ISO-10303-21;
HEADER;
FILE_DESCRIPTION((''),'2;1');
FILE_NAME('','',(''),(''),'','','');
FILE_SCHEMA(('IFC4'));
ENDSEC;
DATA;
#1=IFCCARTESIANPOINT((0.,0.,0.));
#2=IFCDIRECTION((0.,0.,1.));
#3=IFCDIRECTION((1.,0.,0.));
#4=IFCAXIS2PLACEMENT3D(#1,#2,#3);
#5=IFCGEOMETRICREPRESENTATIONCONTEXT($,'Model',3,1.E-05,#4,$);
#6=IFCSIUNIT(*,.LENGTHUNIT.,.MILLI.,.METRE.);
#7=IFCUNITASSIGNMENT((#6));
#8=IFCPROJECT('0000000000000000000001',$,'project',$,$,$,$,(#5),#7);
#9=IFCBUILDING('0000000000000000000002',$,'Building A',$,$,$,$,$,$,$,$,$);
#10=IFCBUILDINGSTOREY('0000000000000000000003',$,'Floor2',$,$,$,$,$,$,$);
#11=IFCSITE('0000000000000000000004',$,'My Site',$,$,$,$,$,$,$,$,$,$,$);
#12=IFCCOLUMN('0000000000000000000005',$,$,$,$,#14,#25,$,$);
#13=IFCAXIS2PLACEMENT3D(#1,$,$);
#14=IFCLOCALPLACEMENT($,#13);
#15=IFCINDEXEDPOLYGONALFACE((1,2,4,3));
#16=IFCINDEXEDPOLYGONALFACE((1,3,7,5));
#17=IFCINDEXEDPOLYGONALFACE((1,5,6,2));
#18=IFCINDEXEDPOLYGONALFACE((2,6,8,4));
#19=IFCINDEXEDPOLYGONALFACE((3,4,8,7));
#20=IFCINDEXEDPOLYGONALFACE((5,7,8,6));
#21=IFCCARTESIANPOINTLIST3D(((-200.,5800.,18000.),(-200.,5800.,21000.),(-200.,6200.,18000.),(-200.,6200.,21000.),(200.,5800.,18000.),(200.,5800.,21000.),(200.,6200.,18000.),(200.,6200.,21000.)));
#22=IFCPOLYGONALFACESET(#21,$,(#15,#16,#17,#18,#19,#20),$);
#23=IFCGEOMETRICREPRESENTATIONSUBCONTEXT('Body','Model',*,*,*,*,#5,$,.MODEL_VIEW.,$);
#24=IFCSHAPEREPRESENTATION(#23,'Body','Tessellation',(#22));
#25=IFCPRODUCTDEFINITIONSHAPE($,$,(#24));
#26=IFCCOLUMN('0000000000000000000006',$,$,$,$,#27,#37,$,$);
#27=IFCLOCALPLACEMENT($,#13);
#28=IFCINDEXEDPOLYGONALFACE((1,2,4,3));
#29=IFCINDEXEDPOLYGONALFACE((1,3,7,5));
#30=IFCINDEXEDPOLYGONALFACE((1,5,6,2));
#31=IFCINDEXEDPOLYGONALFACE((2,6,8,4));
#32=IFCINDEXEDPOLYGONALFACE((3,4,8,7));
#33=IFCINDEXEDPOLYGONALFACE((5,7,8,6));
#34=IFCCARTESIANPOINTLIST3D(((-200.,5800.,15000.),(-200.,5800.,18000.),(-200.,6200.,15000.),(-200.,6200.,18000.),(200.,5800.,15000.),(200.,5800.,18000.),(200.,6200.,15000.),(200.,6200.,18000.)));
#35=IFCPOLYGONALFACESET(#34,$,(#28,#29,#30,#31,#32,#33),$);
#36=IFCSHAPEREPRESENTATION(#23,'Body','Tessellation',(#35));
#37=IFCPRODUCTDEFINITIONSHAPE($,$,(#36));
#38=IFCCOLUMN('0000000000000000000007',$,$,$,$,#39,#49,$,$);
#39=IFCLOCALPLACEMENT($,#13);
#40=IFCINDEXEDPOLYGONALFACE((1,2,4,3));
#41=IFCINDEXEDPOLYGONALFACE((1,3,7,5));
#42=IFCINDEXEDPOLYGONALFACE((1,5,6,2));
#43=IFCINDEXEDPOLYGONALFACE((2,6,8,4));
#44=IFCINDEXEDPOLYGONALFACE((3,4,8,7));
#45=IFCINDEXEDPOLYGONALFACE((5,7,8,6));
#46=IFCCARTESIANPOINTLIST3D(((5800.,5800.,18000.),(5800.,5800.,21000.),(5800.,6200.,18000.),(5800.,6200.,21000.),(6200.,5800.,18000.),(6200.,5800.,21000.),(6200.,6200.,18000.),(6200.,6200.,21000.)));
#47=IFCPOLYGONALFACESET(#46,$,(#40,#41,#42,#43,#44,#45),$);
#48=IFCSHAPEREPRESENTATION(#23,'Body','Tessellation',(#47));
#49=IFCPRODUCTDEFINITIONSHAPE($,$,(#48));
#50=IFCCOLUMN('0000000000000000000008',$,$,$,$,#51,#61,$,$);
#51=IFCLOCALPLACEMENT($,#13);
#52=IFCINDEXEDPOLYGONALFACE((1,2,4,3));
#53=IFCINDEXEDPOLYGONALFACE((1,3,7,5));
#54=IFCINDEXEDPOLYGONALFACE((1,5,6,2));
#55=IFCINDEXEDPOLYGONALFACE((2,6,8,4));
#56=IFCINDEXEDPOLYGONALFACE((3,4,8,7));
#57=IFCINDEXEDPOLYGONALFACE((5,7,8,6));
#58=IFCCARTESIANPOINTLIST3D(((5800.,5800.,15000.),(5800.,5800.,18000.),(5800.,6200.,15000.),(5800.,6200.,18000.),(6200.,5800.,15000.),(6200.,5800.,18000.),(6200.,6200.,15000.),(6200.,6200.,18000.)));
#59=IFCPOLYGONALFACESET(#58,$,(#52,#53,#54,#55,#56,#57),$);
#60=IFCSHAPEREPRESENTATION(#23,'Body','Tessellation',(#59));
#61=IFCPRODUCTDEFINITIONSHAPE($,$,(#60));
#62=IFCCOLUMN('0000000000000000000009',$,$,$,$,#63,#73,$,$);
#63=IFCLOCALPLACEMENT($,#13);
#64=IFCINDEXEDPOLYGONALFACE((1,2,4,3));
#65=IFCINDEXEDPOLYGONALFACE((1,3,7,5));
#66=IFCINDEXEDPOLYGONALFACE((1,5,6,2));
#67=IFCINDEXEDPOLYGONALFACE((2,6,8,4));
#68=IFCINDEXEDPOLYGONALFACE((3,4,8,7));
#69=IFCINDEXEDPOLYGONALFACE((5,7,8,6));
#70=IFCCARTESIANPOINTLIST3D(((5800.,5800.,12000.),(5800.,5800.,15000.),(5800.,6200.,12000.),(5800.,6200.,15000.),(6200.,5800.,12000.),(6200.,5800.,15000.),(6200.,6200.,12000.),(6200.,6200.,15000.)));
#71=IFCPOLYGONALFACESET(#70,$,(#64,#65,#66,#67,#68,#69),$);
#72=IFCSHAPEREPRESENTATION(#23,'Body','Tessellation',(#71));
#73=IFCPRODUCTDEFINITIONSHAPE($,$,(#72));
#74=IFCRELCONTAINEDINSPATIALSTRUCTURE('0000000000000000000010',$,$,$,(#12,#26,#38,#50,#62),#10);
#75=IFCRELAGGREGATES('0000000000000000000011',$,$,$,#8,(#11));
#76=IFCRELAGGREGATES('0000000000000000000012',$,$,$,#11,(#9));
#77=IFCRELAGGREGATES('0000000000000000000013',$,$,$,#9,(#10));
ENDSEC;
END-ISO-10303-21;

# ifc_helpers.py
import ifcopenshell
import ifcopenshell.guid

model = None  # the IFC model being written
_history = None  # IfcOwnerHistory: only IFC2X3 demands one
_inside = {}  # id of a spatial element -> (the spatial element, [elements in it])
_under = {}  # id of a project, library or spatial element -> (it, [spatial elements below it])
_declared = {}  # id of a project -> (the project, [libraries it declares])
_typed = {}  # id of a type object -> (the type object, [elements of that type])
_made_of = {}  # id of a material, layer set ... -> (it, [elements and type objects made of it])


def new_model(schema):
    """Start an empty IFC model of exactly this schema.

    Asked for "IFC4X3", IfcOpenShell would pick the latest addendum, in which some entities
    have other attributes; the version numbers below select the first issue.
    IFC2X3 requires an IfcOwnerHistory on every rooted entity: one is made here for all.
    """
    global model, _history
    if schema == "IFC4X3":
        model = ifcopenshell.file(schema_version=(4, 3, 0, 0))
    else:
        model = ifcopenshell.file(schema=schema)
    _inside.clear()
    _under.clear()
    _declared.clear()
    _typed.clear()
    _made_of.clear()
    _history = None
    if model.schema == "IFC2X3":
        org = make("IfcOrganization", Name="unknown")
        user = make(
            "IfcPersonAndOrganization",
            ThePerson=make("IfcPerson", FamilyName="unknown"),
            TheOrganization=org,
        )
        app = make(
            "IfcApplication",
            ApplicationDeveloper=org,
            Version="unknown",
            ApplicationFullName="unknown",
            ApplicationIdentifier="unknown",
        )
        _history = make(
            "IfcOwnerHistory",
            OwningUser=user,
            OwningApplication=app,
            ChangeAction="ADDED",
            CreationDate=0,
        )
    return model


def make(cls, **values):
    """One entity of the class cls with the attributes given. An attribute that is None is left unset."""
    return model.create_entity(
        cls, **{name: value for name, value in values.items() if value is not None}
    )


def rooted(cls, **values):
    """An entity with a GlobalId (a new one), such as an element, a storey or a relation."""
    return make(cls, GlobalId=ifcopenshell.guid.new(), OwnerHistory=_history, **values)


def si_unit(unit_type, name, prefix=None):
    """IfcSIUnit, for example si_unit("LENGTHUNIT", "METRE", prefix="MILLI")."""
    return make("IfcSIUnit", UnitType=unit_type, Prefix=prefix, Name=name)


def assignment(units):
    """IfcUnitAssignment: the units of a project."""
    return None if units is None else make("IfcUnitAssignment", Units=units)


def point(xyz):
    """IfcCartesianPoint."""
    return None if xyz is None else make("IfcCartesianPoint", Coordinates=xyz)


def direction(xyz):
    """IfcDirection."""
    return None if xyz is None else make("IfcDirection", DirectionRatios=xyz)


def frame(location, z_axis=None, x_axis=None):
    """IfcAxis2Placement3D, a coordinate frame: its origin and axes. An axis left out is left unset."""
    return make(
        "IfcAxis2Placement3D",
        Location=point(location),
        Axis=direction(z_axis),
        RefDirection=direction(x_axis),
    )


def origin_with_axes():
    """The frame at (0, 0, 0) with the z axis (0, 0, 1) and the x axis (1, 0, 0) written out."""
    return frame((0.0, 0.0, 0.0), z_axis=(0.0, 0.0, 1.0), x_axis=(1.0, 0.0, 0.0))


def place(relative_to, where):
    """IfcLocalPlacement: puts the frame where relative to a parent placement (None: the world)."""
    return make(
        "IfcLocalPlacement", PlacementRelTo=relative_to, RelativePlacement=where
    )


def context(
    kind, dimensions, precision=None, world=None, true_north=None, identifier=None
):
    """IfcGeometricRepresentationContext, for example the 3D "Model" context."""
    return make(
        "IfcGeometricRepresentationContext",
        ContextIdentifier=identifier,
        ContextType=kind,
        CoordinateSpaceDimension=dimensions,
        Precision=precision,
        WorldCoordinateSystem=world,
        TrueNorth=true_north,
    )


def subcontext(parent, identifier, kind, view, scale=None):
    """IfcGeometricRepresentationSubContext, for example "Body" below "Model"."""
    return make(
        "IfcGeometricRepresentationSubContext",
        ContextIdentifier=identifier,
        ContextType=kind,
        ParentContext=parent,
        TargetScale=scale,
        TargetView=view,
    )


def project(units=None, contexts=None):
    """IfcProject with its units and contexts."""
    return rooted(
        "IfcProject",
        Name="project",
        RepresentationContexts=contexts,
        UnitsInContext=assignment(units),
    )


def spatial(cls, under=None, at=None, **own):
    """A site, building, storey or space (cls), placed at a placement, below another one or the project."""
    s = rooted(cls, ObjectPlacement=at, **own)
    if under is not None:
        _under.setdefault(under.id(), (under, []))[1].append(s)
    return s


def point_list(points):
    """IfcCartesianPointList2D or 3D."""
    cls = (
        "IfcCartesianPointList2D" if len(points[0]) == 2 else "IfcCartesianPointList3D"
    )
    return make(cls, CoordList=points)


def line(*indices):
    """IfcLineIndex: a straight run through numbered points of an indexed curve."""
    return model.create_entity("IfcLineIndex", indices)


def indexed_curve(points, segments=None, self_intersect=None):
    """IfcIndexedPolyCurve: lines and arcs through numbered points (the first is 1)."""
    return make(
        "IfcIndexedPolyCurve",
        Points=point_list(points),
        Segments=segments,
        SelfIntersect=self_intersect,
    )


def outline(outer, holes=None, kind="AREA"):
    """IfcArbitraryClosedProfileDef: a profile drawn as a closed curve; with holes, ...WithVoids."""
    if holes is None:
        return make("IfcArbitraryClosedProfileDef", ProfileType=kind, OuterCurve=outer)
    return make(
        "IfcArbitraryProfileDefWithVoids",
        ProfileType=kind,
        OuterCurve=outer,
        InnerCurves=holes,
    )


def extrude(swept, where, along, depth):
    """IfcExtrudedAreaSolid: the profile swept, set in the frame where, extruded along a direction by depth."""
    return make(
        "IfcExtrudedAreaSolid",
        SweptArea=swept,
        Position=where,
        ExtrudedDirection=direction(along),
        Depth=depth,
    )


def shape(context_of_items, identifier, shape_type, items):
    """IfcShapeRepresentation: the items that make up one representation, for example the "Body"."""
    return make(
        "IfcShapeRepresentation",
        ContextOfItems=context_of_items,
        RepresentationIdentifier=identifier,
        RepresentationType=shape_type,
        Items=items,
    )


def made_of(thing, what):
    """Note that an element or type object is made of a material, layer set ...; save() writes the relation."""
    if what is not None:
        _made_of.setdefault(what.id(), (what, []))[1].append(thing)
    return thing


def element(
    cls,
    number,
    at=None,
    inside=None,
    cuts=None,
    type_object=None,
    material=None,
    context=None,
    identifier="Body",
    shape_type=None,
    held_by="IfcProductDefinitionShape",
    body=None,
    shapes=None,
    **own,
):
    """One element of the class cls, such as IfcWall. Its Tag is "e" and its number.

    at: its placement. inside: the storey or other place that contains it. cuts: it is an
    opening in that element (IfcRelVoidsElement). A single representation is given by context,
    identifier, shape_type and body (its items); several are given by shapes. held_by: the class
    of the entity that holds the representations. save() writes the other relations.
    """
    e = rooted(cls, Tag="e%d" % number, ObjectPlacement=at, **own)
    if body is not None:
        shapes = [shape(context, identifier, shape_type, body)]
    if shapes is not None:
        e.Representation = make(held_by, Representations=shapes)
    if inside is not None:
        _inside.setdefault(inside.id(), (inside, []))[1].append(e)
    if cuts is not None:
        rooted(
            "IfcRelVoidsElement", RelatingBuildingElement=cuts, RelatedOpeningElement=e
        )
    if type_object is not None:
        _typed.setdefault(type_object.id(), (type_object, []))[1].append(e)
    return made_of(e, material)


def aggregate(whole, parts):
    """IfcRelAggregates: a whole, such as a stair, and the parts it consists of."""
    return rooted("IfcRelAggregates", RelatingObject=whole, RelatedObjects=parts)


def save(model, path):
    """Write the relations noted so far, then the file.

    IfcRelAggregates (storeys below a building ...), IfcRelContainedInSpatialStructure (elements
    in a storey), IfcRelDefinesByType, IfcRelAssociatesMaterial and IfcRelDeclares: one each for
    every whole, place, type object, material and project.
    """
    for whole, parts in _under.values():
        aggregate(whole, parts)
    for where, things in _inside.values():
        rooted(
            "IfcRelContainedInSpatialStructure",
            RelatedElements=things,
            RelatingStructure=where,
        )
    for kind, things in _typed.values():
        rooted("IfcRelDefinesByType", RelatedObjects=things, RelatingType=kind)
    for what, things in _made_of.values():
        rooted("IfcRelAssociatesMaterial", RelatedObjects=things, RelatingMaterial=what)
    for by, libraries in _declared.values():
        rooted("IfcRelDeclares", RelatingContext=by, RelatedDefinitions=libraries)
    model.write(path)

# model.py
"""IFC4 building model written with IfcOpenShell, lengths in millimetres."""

from ifc_helpers import new_model, si_unit, frame, origin_with_axes, place, context, subcontext, project, spatial, line, indexed_curve, outline, extrude, element, save


model = new_model("IFC4")

# Units and contexts
model_context = context("Model", 3, precision=1e-05, world=origin_with_axes())
body_context = subcontext(model_context, "Body", "Model", "MODEL_VIEW")
ifc_project = project(units=[si_unit("LENGTHUNIT", "METRE", prefix="MILLI")], contexts=[model_context])

# Site, building, storey
site = spatial("IfcSite", under=ifc_project, Name="My Site")
building = spatial("IfcBuilding", under=site, Name="Building A")
storey = spatial("IfcBuildingStorey", under=building, Name="Floor2")

# Columns
for number, where, z_axis, x_axis in (
    (1, (0.0, 6000.0, 18000.0), (0.0, 0.0, 1.0), (1.0, 0.0, 0.0)),
    (2, (0.0, 6000.0, 15000.0), (0.0, 0.0, 1.0), (1.0, 0.0, 0.0)),
    (3, (6000.0, 6000.0, 18000.0), (0.0, 0.0, 1.0), (1.0, 0.0, 0.0)),
    (4, (6000.0, 6000.0, 15000.0), (0.0, 0.0, 1.0), (1.0, 0.0, 0.0)),
    (5, (6000.0, 6000.0, 12000.0), (0.0, 0.0, 1.0), (1.0, 0.0, 0.0)),
):
    element("IfcColumn", number, at=place(None, frame(where, z_axis=z_axis, x_axis=x_axis)), inside=storey, context=body_context, shape_type="SweptSolid", body=[
        extrude(outline(indexed_curve([(-200.0, -200.0), (200.0, -200.0), (200.0, 200.0), (-200.0, 200.0)], segments=[line(1, 2, 3, 4, 1)])), origin_with_axes(), (0.0, 0.0, 1.0), 3000.0),
    ])

save(model, "model.ifc")
